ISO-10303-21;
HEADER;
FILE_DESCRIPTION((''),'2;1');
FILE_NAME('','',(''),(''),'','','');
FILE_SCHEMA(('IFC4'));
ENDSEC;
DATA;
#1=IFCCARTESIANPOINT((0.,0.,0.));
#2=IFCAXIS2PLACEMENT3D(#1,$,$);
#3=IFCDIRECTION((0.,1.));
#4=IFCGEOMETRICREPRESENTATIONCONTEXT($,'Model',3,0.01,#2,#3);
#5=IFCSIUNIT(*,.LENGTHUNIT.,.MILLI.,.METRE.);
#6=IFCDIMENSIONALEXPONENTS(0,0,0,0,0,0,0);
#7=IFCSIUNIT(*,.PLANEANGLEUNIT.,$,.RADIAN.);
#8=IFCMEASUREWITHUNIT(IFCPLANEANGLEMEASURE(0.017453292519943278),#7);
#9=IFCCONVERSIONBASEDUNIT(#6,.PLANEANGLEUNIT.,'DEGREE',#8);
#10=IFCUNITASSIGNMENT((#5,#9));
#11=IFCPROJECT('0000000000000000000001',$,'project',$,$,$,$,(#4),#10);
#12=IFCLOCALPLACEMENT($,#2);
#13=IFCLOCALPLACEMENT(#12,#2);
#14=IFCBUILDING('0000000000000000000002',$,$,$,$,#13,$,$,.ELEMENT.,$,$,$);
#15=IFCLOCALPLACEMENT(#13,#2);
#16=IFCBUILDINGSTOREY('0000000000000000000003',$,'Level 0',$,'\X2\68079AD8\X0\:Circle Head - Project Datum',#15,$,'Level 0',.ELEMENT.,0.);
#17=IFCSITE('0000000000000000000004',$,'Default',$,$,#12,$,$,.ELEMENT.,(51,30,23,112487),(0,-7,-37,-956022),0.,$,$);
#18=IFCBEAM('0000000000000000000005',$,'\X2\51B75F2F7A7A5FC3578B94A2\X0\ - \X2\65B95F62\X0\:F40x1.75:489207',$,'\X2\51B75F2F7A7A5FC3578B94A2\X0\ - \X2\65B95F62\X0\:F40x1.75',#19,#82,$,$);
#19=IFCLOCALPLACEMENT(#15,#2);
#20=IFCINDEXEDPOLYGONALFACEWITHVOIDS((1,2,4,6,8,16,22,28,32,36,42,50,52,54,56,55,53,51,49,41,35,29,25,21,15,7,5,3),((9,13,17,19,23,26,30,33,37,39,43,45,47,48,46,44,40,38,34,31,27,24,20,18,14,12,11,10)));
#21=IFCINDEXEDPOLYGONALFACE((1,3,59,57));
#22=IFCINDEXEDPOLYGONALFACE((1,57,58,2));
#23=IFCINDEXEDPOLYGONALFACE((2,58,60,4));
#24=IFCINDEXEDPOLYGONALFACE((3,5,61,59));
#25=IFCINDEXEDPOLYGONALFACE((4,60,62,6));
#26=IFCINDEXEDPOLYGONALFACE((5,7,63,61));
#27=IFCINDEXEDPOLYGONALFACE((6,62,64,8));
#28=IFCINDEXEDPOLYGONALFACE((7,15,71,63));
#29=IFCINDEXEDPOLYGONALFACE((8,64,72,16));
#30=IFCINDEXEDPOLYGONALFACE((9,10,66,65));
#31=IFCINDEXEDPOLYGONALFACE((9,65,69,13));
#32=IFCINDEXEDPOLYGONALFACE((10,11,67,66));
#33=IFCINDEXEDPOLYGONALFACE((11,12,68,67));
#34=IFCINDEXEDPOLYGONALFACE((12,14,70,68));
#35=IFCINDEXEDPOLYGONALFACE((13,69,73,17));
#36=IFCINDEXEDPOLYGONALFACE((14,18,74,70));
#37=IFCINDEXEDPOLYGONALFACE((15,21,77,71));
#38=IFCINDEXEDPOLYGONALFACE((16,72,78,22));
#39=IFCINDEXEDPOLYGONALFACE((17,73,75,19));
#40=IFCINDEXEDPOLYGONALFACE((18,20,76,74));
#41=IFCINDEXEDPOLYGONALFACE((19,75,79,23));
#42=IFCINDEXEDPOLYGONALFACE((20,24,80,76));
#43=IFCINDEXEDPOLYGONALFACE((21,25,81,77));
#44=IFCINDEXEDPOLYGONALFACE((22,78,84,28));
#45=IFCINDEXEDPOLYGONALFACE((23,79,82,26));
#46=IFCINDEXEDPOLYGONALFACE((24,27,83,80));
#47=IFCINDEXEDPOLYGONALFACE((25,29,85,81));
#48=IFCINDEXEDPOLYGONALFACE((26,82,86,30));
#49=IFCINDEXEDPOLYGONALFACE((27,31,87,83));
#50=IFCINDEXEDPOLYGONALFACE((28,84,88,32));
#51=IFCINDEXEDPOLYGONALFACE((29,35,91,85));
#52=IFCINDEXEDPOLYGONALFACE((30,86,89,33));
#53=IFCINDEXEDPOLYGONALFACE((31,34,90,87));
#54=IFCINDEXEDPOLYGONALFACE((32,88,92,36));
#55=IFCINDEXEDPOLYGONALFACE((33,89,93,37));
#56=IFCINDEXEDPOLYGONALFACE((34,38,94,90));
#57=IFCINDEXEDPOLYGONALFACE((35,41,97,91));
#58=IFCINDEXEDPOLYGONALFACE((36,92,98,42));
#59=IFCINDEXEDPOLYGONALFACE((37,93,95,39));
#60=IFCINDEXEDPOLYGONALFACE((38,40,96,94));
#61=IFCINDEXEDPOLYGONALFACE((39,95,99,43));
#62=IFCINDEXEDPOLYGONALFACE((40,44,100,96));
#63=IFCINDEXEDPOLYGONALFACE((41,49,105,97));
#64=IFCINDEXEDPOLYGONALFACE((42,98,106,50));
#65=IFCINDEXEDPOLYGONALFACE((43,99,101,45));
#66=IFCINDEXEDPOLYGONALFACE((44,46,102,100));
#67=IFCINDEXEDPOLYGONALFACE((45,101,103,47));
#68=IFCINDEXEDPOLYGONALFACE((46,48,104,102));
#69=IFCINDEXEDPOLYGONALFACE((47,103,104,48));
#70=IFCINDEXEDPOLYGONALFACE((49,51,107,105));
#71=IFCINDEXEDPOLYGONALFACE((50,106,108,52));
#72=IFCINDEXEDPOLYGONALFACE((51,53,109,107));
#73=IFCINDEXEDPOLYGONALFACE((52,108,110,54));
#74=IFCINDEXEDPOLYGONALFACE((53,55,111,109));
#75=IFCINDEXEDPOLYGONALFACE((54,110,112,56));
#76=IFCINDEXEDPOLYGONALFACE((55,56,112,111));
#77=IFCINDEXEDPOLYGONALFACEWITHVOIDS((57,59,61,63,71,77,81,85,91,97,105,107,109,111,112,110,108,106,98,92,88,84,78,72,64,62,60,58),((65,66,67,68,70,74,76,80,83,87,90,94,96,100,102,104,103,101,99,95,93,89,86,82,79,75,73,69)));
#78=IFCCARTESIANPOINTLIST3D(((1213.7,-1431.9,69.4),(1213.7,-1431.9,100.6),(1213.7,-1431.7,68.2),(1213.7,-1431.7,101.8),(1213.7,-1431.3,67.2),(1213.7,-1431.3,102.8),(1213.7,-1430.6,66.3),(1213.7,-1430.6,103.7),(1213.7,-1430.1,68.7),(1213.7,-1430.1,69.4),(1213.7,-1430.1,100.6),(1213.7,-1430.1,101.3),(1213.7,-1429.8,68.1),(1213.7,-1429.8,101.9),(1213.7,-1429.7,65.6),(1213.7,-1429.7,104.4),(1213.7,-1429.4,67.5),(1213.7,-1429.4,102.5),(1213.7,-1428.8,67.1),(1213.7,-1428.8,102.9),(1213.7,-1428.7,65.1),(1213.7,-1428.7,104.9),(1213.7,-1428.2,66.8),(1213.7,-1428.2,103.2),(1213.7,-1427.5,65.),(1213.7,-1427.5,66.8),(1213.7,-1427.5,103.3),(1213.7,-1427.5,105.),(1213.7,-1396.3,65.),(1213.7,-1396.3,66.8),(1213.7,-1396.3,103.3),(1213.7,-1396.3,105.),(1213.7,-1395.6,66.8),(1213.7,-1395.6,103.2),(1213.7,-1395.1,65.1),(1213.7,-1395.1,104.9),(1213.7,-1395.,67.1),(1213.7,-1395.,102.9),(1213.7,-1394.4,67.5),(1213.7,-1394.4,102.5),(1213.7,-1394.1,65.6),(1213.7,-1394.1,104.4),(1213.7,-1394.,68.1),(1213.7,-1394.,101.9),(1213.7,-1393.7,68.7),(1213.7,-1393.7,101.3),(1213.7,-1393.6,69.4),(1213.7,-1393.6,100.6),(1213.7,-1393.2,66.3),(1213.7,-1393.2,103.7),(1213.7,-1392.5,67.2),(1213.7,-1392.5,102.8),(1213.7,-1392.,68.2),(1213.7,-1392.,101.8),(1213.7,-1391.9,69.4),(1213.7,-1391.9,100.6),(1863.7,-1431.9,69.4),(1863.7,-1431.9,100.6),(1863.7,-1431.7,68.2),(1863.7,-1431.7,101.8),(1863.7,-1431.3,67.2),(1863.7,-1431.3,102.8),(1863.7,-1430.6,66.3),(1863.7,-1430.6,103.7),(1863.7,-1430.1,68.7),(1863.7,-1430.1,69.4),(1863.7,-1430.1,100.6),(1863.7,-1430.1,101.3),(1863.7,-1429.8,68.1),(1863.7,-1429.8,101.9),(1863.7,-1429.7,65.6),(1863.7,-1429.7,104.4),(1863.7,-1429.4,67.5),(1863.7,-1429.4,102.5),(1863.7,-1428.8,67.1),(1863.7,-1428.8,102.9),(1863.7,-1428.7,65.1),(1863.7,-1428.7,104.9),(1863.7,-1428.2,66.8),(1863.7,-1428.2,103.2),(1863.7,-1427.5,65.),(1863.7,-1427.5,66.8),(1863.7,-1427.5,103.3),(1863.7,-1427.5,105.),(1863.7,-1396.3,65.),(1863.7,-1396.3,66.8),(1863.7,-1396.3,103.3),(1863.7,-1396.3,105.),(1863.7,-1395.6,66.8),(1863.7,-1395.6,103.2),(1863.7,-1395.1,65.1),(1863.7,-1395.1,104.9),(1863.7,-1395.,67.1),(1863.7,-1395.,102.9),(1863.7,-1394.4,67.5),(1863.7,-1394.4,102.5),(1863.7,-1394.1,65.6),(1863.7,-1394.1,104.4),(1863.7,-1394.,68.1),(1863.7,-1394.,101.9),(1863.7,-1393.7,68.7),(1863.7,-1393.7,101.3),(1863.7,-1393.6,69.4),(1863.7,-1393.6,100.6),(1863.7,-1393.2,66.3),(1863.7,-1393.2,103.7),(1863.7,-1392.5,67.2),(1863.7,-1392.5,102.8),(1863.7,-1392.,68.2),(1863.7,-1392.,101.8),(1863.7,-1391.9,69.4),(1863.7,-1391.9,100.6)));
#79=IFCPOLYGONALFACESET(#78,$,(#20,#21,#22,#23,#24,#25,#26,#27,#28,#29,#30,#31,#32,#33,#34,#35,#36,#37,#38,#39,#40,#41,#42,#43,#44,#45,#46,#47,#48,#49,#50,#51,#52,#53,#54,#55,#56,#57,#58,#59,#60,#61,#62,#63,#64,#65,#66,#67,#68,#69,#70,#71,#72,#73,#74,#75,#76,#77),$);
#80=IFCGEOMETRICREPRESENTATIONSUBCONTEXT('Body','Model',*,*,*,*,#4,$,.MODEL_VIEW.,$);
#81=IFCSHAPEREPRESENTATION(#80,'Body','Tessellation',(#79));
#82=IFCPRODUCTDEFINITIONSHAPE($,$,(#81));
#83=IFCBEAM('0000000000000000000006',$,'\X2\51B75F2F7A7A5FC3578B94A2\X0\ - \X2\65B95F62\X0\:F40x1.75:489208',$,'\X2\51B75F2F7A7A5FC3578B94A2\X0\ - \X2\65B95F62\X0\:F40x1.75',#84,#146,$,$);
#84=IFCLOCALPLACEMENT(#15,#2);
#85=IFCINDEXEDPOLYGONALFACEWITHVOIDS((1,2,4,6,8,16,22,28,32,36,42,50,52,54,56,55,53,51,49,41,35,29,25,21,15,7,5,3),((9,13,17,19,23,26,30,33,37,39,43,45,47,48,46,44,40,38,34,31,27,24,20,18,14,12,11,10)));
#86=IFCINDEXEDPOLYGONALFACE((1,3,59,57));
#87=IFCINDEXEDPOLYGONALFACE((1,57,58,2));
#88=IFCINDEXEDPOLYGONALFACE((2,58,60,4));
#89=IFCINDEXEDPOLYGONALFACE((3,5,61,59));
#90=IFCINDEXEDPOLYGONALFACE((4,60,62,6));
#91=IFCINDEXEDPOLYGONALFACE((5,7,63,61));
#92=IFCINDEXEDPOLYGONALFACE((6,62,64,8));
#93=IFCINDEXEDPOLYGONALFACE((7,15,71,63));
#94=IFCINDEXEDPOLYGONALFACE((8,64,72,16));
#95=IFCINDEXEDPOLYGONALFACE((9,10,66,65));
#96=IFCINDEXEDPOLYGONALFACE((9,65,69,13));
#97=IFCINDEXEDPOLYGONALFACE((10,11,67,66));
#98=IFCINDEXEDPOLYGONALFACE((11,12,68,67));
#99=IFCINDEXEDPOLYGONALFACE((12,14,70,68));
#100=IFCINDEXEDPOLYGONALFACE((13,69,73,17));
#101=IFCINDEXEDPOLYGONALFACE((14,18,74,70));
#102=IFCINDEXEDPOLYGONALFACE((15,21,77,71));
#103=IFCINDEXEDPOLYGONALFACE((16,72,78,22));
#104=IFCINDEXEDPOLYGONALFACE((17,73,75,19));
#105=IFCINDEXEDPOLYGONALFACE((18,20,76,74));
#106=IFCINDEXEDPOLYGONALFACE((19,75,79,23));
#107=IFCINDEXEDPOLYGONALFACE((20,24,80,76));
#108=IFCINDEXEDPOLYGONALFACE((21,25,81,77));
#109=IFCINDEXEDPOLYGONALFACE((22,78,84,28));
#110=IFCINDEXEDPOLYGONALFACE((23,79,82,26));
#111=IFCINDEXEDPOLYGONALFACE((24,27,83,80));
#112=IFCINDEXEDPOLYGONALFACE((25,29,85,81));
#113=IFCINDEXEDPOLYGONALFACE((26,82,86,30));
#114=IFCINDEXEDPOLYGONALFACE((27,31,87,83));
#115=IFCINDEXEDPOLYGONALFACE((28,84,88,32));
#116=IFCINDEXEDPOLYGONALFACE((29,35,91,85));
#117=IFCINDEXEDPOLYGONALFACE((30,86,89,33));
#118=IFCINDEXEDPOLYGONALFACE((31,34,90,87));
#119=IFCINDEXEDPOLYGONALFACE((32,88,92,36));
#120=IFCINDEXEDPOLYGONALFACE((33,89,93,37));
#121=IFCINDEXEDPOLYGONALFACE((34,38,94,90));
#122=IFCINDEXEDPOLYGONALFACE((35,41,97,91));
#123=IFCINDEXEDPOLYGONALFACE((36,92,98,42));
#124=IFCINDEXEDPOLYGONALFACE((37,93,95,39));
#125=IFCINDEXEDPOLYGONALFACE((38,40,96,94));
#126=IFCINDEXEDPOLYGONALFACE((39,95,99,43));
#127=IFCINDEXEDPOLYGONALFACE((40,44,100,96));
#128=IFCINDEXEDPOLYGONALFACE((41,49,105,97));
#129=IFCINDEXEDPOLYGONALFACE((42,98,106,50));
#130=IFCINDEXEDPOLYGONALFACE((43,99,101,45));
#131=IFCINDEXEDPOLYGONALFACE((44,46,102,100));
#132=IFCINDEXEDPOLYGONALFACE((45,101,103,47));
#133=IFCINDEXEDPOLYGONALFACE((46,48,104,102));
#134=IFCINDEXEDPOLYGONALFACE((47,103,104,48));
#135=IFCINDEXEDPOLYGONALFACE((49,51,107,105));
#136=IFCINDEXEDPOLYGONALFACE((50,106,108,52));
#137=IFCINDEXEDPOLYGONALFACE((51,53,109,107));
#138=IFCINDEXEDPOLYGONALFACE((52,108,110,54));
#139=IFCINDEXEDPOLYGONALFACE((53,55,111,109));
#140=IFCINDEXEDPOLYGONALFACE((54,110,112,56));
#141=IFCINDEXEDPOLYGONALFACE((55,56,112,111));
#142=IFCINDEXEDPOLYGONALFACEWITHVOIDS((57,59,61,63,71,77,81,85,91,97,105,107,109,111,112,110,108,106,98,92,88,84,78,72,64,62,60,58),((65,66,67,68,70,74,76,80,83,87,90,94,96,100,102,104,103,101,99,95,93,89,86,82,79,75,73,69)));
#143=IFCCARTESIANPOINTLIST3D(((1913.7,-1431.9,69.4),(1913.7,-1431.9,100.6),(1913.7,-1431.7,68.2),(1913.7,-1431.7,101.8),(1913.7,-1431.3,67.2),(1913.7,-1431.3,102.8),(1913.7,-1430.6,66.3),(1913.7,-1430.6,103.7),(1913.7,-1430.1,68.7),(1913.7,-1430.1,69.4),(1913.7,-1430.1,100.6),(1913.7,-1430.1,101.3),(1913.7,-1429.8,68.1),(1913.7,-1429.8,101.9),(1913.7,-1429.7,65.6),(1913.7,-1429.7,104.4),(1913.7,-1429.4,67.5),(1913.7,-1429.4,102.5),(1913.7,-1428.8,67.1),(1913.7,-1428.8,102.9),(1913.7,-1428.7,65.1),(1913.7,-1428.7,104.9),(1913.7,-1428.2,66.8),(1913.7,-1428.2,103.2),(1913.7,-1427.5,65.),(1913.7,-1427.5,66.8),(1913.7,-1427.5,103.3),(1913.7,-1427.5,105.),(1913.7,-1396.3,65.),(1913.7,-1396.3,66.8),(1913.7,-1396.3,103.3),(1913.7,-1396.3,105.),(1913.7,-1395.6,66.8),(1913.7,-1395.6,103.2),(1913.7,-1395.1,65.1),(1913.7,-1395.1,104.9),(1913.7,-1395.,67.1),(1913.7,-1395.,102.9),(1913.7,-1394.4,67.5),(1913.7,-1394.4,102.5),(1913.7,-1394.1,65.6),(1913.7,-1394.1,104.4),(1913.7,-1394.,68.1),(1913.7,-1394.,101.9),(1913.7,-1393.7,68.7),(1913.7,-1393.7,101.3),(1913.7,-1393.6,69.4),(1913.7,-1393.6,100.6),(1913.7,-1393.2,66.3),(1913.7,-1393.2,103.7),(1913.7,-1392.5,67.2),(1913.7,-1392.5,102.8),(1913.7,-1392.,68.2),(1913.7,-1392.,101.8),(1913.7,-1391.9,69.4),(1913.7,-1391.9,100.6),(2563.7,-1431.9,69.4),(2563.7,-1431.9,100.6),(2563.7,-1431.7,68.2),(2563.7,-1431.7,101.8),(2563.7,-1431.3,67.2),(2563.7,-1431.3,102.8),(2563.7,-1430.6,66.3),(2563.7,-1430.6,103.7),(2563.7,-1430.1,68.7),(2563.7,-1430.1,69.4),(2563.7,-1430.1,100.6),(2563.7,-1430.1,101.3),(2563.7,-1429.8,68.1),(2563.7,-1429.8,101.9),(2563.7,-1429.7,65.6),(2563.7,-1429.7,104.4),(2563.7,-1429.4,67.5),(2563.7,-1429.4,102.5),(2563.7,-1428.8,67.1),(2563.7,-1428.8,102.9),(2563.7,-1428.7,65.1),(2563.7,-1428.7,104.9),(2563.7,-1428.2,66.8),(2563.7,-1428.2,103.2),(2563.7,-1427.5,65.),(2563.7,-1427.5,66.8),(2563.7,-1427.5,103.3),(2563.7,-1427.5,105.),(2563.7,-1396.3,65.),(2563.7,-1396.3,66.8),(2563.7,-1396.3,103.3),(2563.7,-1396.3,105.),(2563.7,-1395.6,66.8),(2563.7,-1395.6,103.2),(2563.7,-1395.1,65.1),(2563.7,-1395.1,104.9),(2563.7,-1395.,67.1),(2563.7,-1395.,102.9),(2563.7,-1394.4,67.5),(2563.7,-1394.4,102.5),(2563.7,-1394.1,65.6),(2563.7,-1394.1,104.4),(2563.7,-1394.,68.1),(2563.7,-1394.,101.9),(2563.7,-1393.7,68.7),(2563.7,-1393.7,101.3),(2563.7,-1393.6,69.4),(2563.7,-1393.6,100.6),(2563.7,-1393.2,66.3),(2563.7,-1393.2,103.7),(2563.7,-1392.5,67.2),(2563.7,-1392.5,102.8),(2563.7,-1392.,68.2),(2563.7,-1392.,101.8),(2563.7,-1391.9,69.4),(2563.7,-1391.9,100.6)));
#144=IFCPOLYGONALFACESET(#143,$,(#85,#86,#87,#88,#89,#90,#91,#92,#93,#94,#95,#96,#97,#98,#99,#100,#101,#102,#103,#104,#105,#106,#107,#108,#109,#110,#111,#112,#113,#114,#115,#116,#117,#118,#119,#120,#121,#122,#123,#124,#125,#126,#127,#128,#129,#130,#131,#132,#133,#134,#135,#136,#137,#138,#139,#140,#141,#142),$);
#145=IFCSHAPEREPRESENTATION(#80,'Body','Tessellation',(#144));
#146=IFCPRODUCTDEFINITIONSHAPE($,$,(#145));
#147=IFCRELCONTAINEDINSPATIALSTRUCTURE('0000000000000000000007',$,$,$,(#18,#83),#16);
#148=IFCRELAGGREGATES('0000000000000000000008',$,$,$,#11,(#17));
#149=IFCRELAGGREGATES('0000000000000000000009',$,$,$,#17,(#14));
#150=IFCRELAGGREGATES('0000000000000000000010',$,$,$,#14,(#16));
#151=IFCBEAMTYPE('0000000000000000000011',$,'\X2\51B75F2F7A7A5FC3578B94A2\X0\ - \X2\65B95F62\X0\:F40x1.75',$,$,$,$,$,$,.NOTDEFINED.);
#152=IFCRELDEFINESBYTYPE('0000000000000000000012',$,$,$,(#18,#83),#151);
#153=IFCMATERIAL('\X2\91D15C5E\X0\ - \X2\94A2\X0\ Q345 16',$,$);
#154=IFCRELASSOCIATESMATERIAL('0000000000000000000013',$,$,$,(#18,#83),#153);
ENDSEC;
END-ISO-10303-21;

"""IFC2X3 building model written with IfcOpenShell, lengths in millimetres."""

from ifc_helpers import new_model, entity, si_unit, converted_unit, direction, frame, frame_2d, origin, place, context, subcontext, project, spatial, polyline, circle_curve, parameter, trimmed, segment, composite_curve, outline, extrude, material, type_object, element, save


model = new_model("IFC2X3")

# Units and contexts
model_context = context("Model", 3, precision=0.01, world=origin(), true_north=direction((0.0, 1.0)))
body_context = subcontext(model_context, "Body", "Model", "MODEL_VIEW")
ifc_project = project(units=[si_unit("LENGTHUNIT", "METRE", prefix="MILLI"), converted_unit("PLANEANGLEUNIT", "DEGREE", entity("IfcPlaneAngleMeasure", 0.017453292519943278), si_unit("PLANEANGLEUNIT", "RADIAN"), dimensions=[0, 0, 0, 0, 0, 0, 0])], contexts=[model_context])

# Site, building, storey
site_placement = place(None, origin())
site = spatial("IfcSite", under=ifc_project, at=site_placement, Name="Default", CompositionType="ELEMENT", RefLatitude=(51, 30, 23, 112487), RefLongitude=(0, -7, -37, -956022), RefElevation=0.0)
building_placement = place(site_placement, origin())
building = spatial("IfcBuilding", under=site, at=building_placement, CompositionType="ELEMENT")
storey_placement = place(building_placement, origin())
storey = spatial("IfcBuildingStorey", under=building, at=storey_placement, Name="Level 0", ObjectType="标高:Circle Head - Project Datum", LongName="Level 0", CompositionType="ELEMENT", Elevation=0.0)

# Beams
ifc_material_1 = material(Name="金属 - 钢 Q345 16")
beam_type_1 = type_object("IfcBeamType", Name="冷弯空心型钢 - 方形:F40x1.75", PredefinedType="NOTDEFINED")
beam_1_placement = place(storey_placement, frame((1168.7, -1411.9, 105.0)))
element("IfcBeam", 1, at=beam_1_placement, inside=storey, type_object=beam_type_1, material=ifc_material_1, Name="冷弯空心型钢 - 方形:F40x1.75:489207", ObjectType="冷弯空心型钢 - 方形:F40x1.75", context=body_context, shape_type="SweptSolid", body=[
    extrude(outline(composite_curve([segment(trimmed(circle_curve(frame_2d((-15.6, 15.6), x_axis=(1.0, 0.0)), 4.4), [parameter(90.0)], [parameter(180.0)], True, "PARAMETER"), True, "CONTINUOUS"), segment(polyline([(-20.0, 15.6), (-20.0, -15.6)]), True, "CONTINUOUS"), segment(trimmed(circle_curve(frame_2d((-15.6, -15.6), x_axis=(1.0, 0.0)), 4.4), [parameter(180.0)], [parameter(270.0)], True, "PARAMETER"), True, "CONTINUOUS"), segment(polyline([(-15.6, -20.0), (15.6, -20.0)]), True, "CONTINUOUS"), segment(trimmed(circle_curve(frame_2d((15.6, -15.6), x_axis=(1.0, 0.0)), 4.4), [parameter(270.0)], [parameter(0.0)], True, "PARAMETER"), True, "CONTINUOUS"), segment(polyline([(20.0, -15.6), (20.0, 15.6)]), True, "CONTINUOUS"), segment(trimmed(circle_curve(frame_2d((15.6, 15.6), x_axis=(1.0, 0.0)), 4.4), [parameter(0.0)], [parameter(90.0)], True, "PARAMETER"), True, "CONTINUOUS"), segment(polyline([(15.6, 20.0), (-15.6, 20.0)]), True, "CONTINUOUS")], self_intersect=False), holes=[composite_curve([segment(polyline([(-15.6, 18.3), (15.6, 18.3)]), True, "CONTINUOUS"), segment(trimmed(circle_curve(frame_2d((15.6, 15.6), x_axis=(1.0, 0.0)), 2.6), [parameter(0.0)], [parameter(90.0)], True, "PARAMETER"), False, "CONTINUOUS"), segment(polyline([(18.2, 15.6), (18.2, -15.6)]), True, "CONTINUOUS"), segment(trimmed(circle_curve(frame_2d((15.6, -15.6), x_axis=(1.0, 0.0)), 2.6), [parameter(270.0)], [parameter(360.0)], True, "PARAMETER"), False, "CONTINUOUS"), segment(polyline([(15.6, -18.2), (-15.6, -18.2)]), True, "CONTINUOUS"), segment(trimmed(circle_curve(frame_2d((-15.6, -15.6), x_axis=(1.0, 0.0)), 2.6), [parameter(180.0)], [parameter(270.0)], True, "PARAMETER"), False, "CONTINUOUS"), segment(polyline([(-18.3, -15.6), (-18.3, 15.6)]), True, "CONTINUOUS"), segment(trimmed(circle_curve(frame_2d((-15.6, 15.6), x_axis=(1.0, 0.0)), 2.6), [parameter(90.0)], [parameter(180.0)], True, "PARAMETER"), False, "CONTINUOUS")], self_intersect=False)]), frame((45.0, 0.0, -20.0), z_axis=(1.0, 0.0, 0.0), x_axis=(0.0, 1.0, 0.0)), (0.0, 0.0, 1.0), 650.0),
])
beam_2_placement = place(storey_placement, frame((1993.7, -1411.9, 105.0)))
element("IfcBeam", 2, at=beam_2_placement, inside=storey, type_object=beam_type_1, material=ifc_material_1, Name="冷弯空心型钢 - 方形:F40x1.75:489208", ObjectType="冷弯空心型钢 - 方形:F40x1.75", context=body_context, shape_type="SweptSolid", body=[
    extrude(outline(composite_curve([segment(trimmed(circle_curve(frame_2d((-15.6, 15.6), x_axis=(1.0, 0.0)), 4.4), [parameter(90.0)], [parameter(180.0)], True, "PARAMETER"), True, "CONTINUOUS"), segment(polyline([(-20.0, 15.6), (-20.0, -15.6)]), True, "CONTINUOUS"), segment(trimmed(circle_curve(frame_2d((-15.6, -15.6), x_axis=(1.0, 0.0)), 4.4), [parameter(180.0)], [parameter(270.0)], True, "PARAMETER"), True, "CONTINUOUS"), segment(polyline([(-15.6, -20.0), (15.6, -20.0)]), True, "CONTINUOUS"), segment(trimmed(circle_curve(frame_2d((15.6, -15.6), x_axis=(1.0, 0.0)), 4.4), [parameter(270.0)], [parameter(0.0)], True, "PARAMETER"), True, "CONTINUOUS"), segment(polyline([(20.0, -15.6), (20.0, 15.6)]), True, "CONTINUOUS"), segment(trimmed(circle_curve(frame_2d((15.6, 15.6), x_axis=(1.0, 0.0)), 4.4), [parameter(0.0)], [parameter(90.0)], True, "PARAMETER"), True, "CONTINUOUS"), segment(polyline([(15.6, 20.0), (-15.6, 20.0)]), True, "CONTINUOUS")], self_intersect=False), holes=[composite_curve([segment(polyline([(-15.6, 18.3), (15.6, 18.3)]), True, "CONTINUOUS"), segment(trimmed(circle_curve(frame_2d((15.6, 15.6), x_axis=(1.0, 0.0)), 2.6), [parameter(0.0)], [parameter(90.0)], True, "PARAMETER"), False, "CONTINUOUS"), segment(polyline([(18.2, 15.6), (18.2, -15.6)]), True, "CONTINUOUS"), segment(trimmed(circle_curve(frame_2d((15.6, -15.6), x_axis=(1.0, 0.0)), 2.6), [parameter(270.0)], [parameter(360.0)], True, "PARAMETER"), False, "CONTINUOUS"), segment(polyline([(15.6, -18.2), (-15.6, -18.2)]), True, "CONTINUOUS"), segment(trimmed(circle_curve(frame_2d((-15.6, -15.6), x_axis=(1.0, 0.0)), 2.6), [parameter(180.0)], [parameter(270.0)], True, "PARAMETER"), False, "CONTINUOUS"), segment(polyline([(-18.3, -15.6), (-18.3, 15.6)]), True, "CONTINUOUS"), segment(trimmed(circle_curve(frame_2d((-15.6, 15.6), x_axis=(1.0, 0.0)), 2.6), [parameter(90.0)], [parameter(180.0)], True, "PARAMETER"), False, "CONTINUOUS")], self_intersect=False)]), frame((-80.0, 0.0, -20.0), z_axis=(1.0, 0.0, 0.0), x_axis=(0.0, 1.0, 0.0)), (0.0, 0.0, 1.0), 650.0),
])

save(model, "model.ifc")
